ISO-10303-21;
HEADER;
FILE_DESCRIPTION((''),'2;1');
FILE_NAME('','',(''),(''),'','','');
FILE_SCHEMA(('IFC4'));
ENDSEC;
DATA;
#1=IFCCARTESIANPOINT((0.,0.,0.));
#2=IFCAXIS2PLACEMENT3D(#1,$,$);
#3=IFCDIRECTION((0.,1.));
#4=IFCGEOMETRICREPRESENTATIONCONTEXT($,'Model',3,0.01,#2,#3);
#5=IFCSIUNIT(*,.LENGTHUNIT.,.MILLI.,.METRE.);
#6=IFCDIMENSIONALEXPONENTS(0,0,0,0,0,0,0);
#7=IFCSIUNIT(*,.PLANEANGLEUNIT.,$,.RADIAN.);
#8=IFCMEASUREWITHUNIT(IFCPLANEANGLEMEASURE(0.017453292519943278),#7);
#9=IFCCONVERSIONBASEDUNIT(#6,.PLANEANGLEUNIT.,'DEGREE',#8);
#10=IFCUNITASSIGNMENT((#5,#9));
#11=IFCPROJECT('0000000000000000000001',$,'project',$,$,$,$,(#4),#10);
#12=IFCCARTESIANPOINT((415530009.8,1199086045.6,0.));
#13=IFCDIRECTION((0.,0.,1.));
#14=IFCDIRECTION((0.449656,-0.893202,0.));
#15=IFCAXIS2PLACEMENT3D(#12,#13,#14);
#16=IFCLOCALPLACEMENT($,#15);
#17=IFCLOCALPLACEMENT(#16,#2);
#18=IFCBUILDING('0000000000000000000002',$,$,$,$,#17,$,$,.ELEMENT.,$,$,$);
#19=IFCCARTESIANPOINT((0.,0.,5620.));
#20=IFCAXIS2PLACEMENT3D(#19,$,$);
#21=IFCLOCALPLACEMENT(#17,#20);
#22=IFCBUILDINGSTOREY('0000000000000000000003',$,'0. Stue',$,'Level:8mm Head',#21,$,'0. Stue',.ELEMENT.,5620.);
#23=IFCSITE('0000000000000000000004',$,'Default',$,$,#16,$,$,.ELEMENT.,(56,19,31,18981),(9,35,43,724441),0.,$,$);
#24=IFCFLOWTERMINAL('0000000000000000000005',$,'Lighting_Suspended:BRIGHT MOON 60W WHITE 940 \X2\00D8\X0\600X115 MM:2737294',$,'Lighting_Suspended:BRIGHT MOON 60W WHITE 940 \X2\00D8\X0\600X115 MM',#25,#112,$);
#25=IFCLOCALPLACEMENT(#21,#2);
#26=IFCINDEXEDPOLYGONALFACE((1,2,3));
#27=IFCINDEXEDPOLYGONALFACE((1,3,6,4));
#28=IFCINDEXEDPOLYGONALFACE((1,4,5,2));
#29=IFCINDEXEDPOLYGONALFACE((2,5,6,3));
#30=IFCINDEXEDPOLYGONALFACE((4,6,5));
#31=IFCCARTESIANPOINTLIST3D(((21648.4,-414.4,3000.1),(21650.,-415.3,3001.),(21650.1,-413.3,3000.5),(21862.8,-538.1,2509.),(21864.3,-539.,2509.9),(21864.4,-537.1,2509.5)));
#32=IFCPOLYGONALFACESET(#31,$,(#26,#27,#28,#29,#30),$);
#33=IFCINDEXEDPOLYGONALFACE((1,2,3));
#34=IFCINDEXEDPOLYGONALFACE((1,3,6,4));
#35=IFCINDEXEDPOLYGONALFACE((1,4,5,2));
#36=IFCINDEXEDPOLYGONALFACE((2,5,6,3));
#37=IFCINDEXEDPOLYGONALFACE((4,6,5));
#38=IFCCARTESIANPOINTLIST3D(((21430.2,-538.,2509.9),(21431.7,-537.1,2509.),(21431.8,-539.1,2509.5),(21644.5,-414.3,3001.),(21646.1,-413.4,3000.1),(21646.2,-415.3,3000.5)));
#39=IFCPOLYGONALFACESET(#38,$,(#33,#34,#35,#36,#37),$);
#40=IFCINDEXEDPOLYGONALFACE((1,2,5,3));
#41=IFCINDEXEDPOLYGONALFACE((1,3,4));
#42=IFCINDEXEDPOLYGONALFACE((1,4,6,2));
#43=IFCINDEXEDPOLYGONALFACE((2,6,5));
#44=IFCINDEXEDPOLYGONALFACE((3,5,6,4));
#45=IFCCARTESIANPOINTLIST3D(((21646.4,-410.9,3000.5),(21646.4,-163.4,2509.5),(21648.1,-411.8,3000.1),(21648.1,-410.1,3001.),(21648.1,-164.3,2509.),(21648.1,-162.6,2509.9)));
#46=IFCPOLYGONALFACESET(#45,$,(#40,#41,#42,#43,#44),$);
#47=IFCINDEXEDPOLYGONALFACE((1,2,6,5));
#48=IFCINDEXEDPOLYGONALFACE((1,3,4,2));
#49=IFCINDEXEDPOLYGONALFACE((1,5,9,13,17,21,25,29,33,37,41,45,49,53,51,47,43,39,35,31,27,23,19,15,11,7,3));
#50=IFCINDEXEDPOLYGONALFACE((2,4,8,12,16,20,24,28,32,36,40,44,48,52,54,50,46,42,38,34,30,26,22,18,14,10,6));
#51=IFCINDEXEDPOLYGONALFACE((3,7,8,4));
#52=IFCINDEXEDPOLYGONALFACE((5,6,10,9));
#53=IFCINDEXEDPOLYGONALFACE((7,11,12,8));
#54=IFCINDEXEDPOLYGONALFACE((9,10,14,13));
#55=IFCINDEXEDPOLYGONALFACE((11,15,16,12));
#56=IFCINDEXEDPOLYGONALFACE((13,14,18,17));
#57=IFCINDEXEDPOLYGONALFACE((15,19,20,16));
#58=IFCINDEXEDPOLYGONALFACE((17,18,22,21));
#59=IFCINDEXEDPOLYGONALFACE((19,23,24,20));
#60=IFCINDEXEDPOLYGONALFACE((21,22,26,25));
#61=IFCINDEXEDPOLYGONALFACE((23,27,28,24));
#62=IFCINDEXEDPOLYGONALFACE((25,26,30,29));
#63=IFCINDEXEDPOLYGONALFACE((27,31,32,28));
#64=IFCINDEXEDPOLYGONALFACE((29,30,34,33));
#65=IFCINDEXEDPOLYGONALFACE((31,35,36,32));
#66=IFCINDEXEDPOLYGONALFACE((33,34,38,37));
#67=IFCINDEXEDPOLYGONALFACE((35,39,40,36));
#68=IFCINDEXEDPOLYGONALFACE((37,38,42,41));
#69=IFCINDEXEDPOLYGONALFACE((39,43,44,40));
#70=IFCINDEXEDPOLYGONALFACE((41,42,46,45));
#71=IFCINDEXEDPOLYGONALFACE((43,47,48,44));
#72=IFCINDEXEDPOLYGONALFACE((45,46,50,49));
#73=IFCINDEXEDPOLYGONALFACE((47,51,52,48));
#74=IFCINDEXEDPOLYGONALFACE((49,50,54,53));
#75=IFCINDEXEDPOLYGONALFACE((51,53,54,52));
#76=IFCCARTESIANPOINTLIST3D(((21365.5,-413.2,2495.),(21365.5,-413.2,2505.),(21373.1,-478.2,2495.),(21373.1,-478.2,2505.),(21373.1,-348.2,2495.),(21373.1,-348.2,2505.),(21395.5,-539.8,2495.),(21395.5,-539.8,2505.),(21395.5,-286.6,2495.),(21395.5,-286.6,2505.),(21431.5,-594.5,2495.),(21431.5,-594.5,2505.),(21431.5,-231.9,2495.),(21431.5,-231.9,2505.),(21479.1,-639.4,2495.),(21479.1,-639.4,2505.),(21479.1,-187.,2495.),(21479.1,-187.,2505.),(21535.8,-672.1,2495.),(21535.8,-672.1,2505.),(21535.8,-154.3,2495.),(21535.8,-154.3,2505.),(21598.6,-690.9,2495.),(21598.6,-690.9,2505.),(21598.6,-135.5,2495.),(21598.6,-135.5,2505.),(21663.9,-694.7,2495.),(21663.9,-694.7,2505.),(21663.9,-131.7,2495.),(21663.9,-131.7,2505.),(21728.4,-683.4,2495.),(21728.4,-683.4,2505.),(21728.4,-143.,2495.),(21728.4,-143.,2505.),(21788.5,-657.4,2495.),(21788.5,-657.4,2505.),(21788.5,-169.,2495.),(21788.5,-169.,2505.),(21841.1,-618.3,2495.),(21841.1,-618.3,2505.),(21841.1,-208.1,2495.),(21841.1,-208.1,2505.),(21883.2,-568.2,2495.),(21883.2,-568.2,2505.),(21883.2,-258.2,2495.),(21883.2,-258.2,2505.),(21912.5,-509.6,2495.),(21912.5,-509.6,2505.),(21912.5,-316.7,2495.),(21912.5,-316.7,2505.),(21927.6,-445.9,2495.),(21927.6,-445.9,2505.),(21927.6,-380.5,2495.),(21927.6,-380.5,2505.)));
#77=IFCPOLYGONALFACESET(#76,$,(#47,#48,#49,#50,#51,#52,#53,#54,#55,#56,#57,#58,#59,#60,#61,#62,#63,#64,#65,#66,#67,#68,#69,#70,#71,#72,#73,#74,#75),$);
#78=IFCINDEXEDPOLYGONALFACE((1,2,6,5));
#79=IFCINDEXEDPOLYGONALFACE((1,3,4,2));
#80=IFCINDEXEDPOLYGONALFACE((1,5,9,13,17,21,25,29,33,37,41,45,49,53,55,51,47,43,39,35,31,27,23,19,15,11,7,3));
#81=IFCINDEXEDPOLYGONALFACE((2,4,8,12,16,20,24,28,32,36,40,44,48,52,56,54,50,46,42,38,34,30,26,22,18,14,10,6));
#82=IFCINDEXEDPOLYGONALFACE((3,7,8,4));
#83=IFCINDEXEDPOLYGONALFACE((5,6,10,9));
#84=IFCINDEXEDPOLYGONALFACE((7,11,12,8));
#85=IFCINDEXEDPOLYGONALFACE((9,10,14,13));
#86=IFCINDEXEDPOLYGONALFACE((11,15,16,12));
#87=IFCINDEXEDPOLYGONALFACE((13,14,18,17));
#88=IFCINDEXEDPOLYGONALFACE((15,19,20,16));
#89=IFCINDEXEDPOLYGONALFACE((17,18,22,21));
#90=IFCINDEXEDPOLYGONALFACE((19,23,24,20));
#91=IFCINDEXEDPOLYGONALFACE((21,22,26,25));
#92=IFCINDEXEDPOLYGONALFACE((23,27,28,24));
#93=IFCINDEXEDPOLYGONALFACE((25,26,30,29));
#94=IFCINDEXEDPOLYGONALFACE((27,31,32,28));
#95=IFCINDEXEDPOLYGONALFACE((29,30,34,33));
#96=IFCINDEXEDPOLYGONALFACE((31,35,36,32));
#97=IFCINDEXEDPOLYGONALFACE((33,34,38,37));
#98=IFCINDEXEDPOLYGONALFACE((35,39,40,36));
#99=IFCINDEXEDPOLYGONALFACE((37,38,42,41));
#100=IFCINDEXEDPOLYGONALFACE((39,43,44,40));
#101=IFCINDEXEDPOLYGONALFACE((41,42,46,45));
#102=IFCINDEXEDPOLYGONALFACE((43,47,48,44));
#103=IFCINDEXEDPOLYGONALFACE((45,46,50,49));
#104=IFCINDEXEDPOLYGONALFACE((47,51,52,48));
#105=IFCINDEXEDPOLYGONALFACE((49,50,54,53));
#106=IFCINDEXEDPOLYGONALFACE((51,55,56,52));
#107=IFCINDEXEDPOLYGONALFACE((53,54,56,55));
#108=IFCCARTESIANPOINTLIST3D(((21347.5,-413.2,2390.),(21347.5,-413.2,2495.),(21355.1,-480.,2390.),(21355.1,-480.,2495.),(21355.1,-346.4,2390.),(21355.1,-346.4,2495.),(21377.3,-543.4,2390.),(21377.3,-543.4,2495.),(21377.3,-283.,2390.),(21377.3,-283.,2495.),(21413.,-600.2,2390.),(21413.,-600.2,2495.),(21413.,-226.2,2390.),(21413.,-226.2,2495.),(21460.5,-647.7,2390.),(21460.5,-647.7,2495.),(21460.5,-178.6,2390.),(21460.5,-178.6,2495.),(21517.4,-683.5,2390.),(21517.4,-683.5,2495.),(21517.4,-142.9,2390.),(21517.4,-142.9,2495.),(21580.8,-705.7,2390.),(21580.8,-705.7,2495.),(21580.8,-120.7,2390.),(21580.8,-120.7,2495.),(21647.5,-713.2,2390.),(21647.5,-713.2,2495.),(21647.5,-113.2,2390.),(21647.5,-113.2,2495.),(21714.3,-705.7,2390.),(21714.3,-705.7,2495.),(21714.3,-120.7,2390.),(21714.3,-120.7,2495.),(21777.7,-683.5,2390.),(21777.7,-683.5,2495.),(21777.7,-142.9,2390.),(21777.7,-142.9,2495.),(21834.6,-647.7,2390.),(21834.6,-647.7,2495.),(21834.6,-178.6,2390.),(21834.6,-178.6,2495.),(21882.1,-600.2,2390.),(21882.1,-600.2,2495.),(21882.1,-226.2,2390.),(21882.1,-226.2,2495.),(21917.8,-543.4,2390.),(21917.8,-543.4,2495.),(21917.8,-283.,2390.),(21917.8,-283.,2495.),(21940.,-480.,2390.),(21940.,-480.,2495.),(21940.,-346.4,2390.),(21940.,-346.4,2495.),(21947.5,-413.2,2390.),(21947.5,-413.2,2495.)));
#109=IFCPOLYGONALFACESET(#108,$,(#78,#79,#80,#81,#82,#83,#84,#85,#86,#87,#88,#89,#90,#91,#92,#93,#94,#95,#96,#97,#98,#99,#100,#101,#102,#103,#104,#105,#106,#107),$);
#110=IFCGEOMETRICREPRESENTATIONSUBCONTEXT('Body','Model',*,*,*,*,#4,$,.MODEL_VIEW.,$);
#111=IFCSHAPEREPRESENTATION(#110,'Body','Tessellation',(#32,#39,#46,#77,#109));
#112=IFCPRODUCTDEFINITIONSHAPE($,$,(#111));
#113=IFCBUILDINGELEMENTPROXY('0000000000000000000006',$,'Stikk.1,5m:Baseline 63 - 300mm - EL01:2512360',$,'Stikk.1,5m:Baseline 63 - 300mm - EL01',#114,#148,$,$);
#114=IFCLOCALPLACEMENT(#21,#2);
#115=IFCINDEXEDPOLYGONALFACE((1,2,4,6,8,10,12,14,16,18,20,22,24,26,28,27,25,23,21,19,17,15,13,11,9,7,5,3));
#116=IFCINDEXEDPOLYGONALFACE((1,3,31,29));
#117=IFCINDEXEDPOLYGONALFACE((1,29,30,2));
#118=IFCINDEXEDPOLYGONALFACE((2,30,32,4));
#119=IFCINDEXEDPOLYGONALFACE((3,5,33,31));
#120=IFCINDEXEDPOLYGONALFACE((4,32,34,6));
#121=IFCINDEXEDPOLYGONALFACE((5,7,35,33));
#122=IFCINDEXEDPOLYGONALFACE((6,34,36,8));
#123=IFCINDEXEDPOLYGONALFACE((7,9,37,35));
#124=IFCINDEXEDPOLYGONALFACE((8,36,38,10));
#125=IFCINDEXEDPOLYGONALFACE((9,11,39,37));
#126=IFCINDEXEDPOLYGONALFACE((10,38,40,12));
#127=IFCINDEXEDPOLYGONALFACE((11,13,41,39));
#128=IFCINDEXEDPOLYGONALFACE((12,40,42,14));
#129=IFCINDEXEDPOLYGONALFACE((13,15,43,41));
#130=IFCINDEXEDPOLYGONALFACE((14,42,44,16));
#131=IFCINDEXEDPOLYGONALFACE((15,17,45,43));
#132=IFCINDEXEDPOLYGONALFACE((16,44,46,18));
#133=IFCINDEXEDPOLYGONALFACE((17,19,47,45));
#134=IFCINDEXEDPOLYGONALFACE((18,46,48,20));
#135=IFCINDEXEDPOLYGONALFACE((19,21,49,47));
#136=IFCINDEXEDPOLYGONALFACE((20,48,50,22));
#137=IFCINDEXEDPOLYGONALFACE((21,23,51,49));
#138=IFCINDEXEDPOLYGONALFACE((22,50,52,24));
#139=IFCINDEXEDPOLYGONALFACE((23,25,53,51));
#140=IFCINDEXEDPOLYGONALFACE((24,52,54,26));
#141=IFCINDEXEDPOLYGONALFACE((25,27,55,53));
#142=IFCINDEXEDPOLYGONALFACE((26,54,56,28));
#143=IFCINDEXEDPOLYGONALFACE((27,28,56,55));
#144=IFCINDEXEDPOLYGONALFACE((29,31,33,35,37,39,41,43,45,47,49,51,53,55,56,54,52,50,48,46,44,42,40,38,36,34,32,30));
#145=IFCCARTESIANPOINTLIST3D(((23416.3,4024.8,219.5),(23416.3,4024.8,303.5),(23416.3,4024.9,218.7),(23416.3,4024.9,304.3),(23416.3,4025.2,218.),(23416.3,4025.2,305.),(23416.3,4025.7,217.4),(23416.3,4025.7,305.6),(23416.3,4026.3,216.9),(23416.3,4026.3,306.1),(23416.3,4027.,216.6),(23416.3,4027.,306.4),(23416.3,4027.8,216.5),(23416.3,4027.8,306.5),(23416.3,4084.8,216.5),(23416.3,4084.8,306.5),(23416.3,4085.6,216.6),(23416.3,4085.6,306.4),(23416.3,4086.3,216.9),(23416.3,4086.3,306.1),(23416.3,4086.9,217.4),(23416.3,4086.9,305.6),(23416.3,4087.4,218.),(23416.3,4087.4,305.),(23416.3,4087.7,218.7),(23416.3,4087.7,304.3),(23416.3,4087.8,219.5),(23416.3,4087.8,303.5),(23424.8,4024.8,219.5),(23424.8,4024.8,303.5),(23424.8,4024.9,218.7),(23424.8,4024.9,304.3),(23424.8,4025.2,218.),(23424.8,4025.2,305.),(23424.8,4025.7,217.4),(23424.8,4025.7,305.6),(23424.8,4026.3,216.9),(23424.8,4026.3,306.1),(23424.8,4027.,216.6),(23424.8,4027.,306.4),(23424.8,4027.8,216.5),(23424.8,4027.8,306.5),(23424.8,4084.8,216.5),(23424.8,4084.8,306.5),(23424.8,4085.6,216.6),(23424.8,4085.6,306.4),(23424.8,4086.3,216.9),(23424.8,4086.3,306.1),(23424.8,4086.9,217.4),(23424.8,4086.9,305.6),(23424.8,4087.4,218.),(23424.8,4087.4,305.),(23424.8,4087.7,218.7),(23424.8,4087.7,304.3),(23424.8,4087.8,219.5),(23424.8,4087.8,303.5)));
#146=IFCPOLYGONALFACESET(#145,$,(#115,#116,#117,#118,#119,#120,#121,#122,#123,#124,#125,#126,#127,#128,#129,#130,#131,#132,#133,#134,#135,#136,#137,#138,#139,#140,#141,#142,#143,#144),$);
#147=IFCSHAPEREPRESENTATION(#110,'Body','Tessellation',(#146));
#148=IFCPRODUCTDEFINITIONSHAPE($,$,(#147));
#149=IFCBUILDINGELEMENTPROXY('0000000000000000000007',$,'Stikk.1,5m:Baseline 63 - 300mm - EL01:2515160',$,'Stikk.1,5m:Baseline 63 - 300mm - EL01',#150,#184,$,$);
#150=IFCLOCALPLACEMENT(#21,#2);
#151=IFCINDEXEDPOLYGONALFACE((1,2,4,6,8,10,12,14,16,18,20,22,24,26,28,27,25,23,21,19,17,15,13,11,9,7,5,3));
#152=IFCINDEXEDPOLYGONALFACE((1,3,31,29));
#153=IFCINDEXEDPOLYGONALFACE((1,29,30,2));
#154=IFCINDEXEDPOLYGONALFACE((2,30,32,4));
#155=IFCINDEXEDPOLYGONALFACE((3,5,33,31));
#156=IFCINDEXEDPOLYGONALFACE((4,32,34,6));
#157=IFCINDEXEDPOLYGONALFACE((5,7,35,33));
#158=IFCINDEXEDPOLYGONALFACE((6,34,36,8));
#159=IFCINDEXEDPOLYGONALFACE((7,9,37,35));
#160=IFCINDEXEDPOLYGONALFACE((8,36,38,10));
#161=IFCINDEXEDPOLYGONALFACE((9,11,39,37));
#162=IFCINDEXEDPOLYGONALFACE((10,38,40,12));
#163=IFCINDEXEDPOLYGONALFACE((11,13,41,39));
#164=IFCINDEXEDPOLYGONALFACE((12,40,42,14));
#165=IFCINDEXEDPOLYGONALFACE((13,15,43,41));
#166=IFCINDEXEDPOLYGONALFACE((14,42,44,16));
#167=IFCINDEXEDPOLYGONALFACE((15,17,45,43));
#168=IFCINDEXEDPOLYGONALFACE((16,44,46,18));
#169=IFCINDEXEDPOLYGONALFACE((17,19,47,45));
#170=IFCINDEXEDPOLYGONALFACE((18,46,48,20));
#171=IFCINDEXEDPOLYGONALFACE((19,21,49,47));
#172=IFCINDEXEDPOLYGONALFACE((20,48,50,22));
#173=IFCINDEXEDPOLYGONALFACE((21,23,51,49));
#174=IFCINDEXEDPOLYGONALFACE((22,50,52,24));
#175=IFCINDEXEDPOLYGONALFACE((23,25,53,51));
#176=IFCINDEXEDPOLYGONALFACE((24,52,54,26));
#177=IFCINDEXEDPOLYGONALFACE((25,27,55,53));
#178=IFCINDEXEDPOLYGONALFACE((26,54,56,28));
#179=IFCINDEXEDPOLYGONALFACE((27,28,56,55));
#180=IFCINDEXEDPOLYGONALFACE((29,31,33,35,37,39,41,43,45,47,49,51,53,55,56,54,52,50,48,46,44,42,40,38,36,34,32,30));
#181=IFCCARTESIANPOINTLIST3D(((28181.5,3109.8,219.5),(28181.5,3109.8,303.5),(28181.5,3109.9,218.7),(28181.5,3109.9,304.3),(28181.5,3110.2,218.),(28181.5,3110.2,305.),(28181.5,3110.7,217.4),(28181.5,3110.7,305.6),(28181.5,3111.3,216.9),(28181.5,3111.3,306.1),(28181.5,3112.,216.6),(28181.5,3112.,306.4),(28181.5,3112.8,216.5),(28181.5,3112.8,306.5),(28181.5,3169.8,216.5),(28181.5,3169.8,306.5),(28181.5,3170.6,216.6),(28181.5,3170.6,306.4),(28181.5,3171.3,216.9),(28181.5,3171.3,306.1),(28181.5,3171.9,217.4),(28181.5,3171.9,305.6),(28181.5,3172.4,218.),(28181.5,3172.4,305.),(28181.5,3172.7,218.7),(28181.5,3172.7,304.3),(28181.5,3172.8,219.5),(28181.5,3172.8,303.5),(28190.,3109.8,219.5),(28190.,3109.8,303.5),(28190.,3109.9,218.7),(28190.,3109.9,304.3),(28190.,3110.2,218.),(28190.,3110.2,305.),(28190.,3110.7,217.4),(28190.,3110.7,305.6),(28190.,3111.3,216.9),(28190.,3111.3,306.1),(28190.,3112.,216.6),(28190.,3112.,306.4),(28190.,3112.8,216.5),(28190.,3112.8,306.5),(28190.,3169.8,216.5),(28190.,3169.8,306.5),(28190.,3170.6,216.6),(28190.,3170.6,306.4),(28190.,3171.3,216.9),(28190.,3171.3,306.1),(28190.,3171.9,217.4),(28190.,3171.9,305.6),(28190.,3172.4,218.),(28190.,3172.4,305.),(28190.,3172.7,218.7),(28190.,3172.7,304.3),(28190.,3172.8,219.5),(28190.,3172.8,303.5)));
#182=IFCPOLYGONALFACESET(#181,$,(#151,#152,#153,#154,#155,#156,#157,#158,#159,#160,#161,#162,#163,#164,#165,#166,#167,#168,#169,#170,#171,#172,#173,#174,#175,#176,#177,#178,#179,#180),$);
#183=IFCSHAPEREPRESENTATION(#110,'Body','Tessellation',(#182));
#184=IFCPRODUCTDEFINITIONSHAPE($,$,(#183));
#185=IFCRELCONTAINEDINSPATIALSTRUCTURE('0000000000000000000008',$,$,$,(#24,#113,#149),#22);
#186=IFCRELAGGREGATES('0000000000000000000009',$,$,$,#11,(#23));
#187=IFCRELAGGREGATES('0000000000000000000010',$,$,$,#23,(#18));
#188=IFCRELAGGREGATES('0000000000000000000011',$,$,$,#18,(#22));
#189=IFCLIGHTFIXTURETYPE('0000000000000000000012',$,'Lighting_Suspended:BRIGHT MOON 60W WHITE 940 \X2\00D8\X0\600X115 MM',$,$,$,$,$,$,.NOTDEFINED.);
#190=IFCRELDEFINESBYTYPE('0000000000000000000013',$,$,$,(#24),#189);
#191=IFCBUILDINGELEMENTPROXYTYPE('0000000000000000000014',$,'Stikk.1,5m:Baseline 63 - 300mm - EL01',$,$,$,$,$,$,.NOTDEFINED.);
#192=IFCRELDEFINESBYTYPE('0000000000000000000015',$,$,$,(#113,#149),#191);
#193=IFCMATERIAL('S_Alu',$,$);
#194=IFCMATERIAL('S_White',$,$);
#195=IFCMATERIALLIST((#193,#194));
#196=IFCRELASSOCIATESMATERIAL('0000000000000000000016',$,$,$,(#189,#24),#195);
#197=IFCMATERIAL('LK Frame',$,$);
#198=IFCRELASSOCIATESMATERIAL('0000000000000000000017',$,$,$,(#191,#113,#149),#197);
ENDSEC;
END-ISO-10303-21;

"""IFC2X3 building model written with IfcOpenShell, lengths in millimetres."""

from ifc_helpers import new_model, entity, si_unit, converted_unit, direction, frame, frame_2d, origin, place, context, subcontext, project, spatial, polyline, circle_curve, parameter, trimmed, segment, composite_curve, circle, outline, extrude, source, transform, mapped, material, material_list, type_object, type_shapes, element, save


model = new_model("IFC2X3")

# Units and contexts
model_context = context("Model", 3, precision=0.01, world=origin(), true_north=direction((0.0, 1.0)))
body_context = subcontext(model_context, "Body", "Model", "MODEL_VIEW")
ifc_project = project(units=[si_unit("LENGTHUNIT", "METRE", prefix="MILLI"), converted_unit("PLANEANGLEUNIT", "DEGREE", entity("IfcPlaneAngleMeasure", 0.017453292519943278), si_unit("PLANEANGLEUNIT", "RADIAN"), dimensions=[0, 0, 0, 0, 0, 0, 0])], contexts=[model_context])

# Site, building, storey
site_placement = place(None, frame((415530009.8, 1199086045.6, 0.0), z_axis=(0.0, 0.0, 1.0), x_axis=(0.449656, -0.893202, 0.0)))
site = spatial("IfcSite", under=ifc_project, at=site_placement, Name="Default", CompositionType="ELEMENT", RefLatitude=(56, 19, 31, 18981), RefLongitude=(9, 35, 43, 724441), RefElevation=0.0)
building_placement = place(site_placement, origin())
building = spatial("IfcBuilding", under=site, at=building_placement, CompositionType="ELEMENT")
storey_placement = place(building_placement, frame((0.0, 0.0, 5620.0)))
storey = spatial("IfcBuildingStorey", under=building, at=storey_placement, Name="0. Stue", ObjectType="Level:8mm Head", LongName="0. Stue", CompositionType="ELEMENT", Elevation=5620.0)

# Flow terminal
ifc_material_1 = material(Name="S_Alu")
ifc_material_2 = material(Name="S_White")
ifc_material_list_1 = material_list([ifc_material_1, ifc_material_2])
light_fixture_type_1 = type_object("IfcLightFixtureType", Name="Lighting_Suspended:BRIGHT MOON 60W WHITE 940 Ø600X115 MM", PredefinedType="NOTDEFINED", material=ifc_material_list_1)
shared_shape_1 = source(origin(), body_context, "Body", "SweptSolid", [
    extrude(outline(polyline([(-1.0, -0.6), (1.0, -0.6), (0.0, 1.2), (-1.0, -0.6)])), frame((-216.3, 124.9, -495.5), z_axis=(0.389771, -0.225034, 0.892994), x_axis=(-0.773355, 0.446497, 0.450069)), (0.0, 0.0, 1.0), 549.9),
    extrude(outline(polyline([(-1.0, -0.6), (1.0, -0.6), (0.0, 1.2), (-1.0, -0.6)])), frame((216.3, 124.9, -495.5), z_axis=(-0.389771, -0.225034, 0.892994), x_axis=(0.773355, 0.446497, 0.450069)), (0.0, 0.0, 1.0), 549.9),
    extrude(outline(polyline([(-1.0, -0.6), (1.0, -0.6), (0.0, 1.2), (-1.0, -0.6)])), frame((0.0, -249.7, -495.5), z_axis=(0.0, 0.450069, 0.892994), x_axis=(0.0, -0.892994, 0.450069)), (0.0, 0.0, 1.0), 549.9),
    extrude(circle(Radius=282.0, at=frame_2d((0.0, 0.0), x_axis=(1.0, 0.0))), frame((0.0, 0.0, -510.0)), (0.0, 0.0, 1.0), 10.0),
    extrude(circle(Radius=300.0, at=frame_2d((0.0, 0.0), x_axis=(1.0, 0.0))), frame((0.0, 0.0, -615.0)), (0.0, 0.0, 1.0), 105.0),
])
type_shapes(light_fixture_type_1, [shared_shape_1])
flow_terminal_1_placement = place(storey_placement, frame((21647.5, -413.2, 3005.0), z_axis=(0.0, 0.0, 1.0), x_axis=(-1.0, 0.0, 0.0)))
element("IfcFlowTerminal", 1, at=flow_terminal_1_placement, inside=storey, type_object=light_fixture_type_1, material=ifc_material_list_1, Name="Lighting_Suspended:BRIGHT MOON 60W WHITE 940 Ø600X115 MM:2737294", ObjectType="Lighting_Suspended:BRIGHT MOON 60W WHITE 940 Ø600X115 MM", context=body_context, shape_type="MappedRepresentation", body=[
    mapped(shared_shape_1, transform((0.0, 0.0, 0.0), scale=1.0)),
])

# Building element proxies
ifc_material_3 = material(Name="LK Frame")
building_element_proxy_type_1 = type_object("IfcBuildingElementProxyType", Name="Stikk.1,5m:Baseline 63 - 300mm - EL01", PredefinedType="NOTDEFINED", material=ifc_material_3)
shared_shape_2 = source(origin(), body_context, "Body", "SweptSolid", [
    extrude(outline(composite_curve([segment(polyline([(-42.0, -31.5), (42.0, -31.5)]), True, "CONTINUOUS"), segment(trimmed(circle_curve(frame_2d((42.0, -28.5), x_axis=(-1.0, 0.0)), 3.0), [parameter(90.0)], [parameter(180.0)], True, "PARAMETER"), True, "CONTINUOUS"), segment(polyline([(45.0, -28.5), (45.0, 28.5)]), True, "CONTINUOUS"), segment(trimmed(circle_curve(frame_2d((42.0, 28.5), x_axis=(-1.0, 0.0)), 3.0), [parameter(180.0)], [parameter(270.0)], True, "PARAMETER"), True, "CONTINUOUS"), segment(polyline([(42.0, 31.5), (-42.0, 31.5)]), True, "CONTINUOUS"), segment(trimmed(circle_curve(frame_2d((-42.0, 28.5), x_axis=(1.0, 0.0)), 3.0), [parameter(90.0)], [parameter(180.0)], True, "PARAMETER"), True, "CONTINUOUS"), segment(polyline([(-45.0, 28.5), (-45.0, -28.5)]), True, "CONTINUOUS"), segment(trimmed(circle_curve(frame_2d((-42.0, -28.5), x_axis=(1.0, 0.0)), 3.0), [parameter(180.0)], [parameter(270.0)], True, "PARAMETER"), True, "CONTINUOUS")], self_intersect=False)), frame((0.0, -38.5, 0.0), z_axis=(0.0, 0.0, 1.0), x_axis=(0.0, 1.0, 0.0)), (0.0, 0.0, 1.0), 8.5),
])
type_shapes(building_element_proxy_type_1, [shared_shape_2])
for number, where, z_axis, x_axis, name in (
    (2, (23424.8, 4056.3, 300.0), (-1.0, 0.0, 0.0), (0.0, -1.0, 0.0), "Stikk.1,5m:Baseline 63 - 300mm - EL01:2512360"),
    (3, (28190.0, 3141.3, 300.0), (-1.0, 0.0, 0.0), (0.0, -1.0, 0.0), "Stikk.1,5m:Baseline 63 - 300mm - EL01:2515160"),
):
    element("IfcBuildingElementProxy", number, at=place(storey_placement, frame(where, z_axis=z_axis, x_axis=x_axis)), inside=storey, type_object=building_element_proxy_type_1, material=ifc_material_3, Name=name, ObjectType="Stikk.1,5m:Baseline 63 - 300mm - EL01", context=body_context, shape_type="MappedRepresentation", body=[
        mapped(shared_shape_2, transform((0.0, 0.0, 0.0), scale=1.0)),
    ])

save(model, "model.ifc")
